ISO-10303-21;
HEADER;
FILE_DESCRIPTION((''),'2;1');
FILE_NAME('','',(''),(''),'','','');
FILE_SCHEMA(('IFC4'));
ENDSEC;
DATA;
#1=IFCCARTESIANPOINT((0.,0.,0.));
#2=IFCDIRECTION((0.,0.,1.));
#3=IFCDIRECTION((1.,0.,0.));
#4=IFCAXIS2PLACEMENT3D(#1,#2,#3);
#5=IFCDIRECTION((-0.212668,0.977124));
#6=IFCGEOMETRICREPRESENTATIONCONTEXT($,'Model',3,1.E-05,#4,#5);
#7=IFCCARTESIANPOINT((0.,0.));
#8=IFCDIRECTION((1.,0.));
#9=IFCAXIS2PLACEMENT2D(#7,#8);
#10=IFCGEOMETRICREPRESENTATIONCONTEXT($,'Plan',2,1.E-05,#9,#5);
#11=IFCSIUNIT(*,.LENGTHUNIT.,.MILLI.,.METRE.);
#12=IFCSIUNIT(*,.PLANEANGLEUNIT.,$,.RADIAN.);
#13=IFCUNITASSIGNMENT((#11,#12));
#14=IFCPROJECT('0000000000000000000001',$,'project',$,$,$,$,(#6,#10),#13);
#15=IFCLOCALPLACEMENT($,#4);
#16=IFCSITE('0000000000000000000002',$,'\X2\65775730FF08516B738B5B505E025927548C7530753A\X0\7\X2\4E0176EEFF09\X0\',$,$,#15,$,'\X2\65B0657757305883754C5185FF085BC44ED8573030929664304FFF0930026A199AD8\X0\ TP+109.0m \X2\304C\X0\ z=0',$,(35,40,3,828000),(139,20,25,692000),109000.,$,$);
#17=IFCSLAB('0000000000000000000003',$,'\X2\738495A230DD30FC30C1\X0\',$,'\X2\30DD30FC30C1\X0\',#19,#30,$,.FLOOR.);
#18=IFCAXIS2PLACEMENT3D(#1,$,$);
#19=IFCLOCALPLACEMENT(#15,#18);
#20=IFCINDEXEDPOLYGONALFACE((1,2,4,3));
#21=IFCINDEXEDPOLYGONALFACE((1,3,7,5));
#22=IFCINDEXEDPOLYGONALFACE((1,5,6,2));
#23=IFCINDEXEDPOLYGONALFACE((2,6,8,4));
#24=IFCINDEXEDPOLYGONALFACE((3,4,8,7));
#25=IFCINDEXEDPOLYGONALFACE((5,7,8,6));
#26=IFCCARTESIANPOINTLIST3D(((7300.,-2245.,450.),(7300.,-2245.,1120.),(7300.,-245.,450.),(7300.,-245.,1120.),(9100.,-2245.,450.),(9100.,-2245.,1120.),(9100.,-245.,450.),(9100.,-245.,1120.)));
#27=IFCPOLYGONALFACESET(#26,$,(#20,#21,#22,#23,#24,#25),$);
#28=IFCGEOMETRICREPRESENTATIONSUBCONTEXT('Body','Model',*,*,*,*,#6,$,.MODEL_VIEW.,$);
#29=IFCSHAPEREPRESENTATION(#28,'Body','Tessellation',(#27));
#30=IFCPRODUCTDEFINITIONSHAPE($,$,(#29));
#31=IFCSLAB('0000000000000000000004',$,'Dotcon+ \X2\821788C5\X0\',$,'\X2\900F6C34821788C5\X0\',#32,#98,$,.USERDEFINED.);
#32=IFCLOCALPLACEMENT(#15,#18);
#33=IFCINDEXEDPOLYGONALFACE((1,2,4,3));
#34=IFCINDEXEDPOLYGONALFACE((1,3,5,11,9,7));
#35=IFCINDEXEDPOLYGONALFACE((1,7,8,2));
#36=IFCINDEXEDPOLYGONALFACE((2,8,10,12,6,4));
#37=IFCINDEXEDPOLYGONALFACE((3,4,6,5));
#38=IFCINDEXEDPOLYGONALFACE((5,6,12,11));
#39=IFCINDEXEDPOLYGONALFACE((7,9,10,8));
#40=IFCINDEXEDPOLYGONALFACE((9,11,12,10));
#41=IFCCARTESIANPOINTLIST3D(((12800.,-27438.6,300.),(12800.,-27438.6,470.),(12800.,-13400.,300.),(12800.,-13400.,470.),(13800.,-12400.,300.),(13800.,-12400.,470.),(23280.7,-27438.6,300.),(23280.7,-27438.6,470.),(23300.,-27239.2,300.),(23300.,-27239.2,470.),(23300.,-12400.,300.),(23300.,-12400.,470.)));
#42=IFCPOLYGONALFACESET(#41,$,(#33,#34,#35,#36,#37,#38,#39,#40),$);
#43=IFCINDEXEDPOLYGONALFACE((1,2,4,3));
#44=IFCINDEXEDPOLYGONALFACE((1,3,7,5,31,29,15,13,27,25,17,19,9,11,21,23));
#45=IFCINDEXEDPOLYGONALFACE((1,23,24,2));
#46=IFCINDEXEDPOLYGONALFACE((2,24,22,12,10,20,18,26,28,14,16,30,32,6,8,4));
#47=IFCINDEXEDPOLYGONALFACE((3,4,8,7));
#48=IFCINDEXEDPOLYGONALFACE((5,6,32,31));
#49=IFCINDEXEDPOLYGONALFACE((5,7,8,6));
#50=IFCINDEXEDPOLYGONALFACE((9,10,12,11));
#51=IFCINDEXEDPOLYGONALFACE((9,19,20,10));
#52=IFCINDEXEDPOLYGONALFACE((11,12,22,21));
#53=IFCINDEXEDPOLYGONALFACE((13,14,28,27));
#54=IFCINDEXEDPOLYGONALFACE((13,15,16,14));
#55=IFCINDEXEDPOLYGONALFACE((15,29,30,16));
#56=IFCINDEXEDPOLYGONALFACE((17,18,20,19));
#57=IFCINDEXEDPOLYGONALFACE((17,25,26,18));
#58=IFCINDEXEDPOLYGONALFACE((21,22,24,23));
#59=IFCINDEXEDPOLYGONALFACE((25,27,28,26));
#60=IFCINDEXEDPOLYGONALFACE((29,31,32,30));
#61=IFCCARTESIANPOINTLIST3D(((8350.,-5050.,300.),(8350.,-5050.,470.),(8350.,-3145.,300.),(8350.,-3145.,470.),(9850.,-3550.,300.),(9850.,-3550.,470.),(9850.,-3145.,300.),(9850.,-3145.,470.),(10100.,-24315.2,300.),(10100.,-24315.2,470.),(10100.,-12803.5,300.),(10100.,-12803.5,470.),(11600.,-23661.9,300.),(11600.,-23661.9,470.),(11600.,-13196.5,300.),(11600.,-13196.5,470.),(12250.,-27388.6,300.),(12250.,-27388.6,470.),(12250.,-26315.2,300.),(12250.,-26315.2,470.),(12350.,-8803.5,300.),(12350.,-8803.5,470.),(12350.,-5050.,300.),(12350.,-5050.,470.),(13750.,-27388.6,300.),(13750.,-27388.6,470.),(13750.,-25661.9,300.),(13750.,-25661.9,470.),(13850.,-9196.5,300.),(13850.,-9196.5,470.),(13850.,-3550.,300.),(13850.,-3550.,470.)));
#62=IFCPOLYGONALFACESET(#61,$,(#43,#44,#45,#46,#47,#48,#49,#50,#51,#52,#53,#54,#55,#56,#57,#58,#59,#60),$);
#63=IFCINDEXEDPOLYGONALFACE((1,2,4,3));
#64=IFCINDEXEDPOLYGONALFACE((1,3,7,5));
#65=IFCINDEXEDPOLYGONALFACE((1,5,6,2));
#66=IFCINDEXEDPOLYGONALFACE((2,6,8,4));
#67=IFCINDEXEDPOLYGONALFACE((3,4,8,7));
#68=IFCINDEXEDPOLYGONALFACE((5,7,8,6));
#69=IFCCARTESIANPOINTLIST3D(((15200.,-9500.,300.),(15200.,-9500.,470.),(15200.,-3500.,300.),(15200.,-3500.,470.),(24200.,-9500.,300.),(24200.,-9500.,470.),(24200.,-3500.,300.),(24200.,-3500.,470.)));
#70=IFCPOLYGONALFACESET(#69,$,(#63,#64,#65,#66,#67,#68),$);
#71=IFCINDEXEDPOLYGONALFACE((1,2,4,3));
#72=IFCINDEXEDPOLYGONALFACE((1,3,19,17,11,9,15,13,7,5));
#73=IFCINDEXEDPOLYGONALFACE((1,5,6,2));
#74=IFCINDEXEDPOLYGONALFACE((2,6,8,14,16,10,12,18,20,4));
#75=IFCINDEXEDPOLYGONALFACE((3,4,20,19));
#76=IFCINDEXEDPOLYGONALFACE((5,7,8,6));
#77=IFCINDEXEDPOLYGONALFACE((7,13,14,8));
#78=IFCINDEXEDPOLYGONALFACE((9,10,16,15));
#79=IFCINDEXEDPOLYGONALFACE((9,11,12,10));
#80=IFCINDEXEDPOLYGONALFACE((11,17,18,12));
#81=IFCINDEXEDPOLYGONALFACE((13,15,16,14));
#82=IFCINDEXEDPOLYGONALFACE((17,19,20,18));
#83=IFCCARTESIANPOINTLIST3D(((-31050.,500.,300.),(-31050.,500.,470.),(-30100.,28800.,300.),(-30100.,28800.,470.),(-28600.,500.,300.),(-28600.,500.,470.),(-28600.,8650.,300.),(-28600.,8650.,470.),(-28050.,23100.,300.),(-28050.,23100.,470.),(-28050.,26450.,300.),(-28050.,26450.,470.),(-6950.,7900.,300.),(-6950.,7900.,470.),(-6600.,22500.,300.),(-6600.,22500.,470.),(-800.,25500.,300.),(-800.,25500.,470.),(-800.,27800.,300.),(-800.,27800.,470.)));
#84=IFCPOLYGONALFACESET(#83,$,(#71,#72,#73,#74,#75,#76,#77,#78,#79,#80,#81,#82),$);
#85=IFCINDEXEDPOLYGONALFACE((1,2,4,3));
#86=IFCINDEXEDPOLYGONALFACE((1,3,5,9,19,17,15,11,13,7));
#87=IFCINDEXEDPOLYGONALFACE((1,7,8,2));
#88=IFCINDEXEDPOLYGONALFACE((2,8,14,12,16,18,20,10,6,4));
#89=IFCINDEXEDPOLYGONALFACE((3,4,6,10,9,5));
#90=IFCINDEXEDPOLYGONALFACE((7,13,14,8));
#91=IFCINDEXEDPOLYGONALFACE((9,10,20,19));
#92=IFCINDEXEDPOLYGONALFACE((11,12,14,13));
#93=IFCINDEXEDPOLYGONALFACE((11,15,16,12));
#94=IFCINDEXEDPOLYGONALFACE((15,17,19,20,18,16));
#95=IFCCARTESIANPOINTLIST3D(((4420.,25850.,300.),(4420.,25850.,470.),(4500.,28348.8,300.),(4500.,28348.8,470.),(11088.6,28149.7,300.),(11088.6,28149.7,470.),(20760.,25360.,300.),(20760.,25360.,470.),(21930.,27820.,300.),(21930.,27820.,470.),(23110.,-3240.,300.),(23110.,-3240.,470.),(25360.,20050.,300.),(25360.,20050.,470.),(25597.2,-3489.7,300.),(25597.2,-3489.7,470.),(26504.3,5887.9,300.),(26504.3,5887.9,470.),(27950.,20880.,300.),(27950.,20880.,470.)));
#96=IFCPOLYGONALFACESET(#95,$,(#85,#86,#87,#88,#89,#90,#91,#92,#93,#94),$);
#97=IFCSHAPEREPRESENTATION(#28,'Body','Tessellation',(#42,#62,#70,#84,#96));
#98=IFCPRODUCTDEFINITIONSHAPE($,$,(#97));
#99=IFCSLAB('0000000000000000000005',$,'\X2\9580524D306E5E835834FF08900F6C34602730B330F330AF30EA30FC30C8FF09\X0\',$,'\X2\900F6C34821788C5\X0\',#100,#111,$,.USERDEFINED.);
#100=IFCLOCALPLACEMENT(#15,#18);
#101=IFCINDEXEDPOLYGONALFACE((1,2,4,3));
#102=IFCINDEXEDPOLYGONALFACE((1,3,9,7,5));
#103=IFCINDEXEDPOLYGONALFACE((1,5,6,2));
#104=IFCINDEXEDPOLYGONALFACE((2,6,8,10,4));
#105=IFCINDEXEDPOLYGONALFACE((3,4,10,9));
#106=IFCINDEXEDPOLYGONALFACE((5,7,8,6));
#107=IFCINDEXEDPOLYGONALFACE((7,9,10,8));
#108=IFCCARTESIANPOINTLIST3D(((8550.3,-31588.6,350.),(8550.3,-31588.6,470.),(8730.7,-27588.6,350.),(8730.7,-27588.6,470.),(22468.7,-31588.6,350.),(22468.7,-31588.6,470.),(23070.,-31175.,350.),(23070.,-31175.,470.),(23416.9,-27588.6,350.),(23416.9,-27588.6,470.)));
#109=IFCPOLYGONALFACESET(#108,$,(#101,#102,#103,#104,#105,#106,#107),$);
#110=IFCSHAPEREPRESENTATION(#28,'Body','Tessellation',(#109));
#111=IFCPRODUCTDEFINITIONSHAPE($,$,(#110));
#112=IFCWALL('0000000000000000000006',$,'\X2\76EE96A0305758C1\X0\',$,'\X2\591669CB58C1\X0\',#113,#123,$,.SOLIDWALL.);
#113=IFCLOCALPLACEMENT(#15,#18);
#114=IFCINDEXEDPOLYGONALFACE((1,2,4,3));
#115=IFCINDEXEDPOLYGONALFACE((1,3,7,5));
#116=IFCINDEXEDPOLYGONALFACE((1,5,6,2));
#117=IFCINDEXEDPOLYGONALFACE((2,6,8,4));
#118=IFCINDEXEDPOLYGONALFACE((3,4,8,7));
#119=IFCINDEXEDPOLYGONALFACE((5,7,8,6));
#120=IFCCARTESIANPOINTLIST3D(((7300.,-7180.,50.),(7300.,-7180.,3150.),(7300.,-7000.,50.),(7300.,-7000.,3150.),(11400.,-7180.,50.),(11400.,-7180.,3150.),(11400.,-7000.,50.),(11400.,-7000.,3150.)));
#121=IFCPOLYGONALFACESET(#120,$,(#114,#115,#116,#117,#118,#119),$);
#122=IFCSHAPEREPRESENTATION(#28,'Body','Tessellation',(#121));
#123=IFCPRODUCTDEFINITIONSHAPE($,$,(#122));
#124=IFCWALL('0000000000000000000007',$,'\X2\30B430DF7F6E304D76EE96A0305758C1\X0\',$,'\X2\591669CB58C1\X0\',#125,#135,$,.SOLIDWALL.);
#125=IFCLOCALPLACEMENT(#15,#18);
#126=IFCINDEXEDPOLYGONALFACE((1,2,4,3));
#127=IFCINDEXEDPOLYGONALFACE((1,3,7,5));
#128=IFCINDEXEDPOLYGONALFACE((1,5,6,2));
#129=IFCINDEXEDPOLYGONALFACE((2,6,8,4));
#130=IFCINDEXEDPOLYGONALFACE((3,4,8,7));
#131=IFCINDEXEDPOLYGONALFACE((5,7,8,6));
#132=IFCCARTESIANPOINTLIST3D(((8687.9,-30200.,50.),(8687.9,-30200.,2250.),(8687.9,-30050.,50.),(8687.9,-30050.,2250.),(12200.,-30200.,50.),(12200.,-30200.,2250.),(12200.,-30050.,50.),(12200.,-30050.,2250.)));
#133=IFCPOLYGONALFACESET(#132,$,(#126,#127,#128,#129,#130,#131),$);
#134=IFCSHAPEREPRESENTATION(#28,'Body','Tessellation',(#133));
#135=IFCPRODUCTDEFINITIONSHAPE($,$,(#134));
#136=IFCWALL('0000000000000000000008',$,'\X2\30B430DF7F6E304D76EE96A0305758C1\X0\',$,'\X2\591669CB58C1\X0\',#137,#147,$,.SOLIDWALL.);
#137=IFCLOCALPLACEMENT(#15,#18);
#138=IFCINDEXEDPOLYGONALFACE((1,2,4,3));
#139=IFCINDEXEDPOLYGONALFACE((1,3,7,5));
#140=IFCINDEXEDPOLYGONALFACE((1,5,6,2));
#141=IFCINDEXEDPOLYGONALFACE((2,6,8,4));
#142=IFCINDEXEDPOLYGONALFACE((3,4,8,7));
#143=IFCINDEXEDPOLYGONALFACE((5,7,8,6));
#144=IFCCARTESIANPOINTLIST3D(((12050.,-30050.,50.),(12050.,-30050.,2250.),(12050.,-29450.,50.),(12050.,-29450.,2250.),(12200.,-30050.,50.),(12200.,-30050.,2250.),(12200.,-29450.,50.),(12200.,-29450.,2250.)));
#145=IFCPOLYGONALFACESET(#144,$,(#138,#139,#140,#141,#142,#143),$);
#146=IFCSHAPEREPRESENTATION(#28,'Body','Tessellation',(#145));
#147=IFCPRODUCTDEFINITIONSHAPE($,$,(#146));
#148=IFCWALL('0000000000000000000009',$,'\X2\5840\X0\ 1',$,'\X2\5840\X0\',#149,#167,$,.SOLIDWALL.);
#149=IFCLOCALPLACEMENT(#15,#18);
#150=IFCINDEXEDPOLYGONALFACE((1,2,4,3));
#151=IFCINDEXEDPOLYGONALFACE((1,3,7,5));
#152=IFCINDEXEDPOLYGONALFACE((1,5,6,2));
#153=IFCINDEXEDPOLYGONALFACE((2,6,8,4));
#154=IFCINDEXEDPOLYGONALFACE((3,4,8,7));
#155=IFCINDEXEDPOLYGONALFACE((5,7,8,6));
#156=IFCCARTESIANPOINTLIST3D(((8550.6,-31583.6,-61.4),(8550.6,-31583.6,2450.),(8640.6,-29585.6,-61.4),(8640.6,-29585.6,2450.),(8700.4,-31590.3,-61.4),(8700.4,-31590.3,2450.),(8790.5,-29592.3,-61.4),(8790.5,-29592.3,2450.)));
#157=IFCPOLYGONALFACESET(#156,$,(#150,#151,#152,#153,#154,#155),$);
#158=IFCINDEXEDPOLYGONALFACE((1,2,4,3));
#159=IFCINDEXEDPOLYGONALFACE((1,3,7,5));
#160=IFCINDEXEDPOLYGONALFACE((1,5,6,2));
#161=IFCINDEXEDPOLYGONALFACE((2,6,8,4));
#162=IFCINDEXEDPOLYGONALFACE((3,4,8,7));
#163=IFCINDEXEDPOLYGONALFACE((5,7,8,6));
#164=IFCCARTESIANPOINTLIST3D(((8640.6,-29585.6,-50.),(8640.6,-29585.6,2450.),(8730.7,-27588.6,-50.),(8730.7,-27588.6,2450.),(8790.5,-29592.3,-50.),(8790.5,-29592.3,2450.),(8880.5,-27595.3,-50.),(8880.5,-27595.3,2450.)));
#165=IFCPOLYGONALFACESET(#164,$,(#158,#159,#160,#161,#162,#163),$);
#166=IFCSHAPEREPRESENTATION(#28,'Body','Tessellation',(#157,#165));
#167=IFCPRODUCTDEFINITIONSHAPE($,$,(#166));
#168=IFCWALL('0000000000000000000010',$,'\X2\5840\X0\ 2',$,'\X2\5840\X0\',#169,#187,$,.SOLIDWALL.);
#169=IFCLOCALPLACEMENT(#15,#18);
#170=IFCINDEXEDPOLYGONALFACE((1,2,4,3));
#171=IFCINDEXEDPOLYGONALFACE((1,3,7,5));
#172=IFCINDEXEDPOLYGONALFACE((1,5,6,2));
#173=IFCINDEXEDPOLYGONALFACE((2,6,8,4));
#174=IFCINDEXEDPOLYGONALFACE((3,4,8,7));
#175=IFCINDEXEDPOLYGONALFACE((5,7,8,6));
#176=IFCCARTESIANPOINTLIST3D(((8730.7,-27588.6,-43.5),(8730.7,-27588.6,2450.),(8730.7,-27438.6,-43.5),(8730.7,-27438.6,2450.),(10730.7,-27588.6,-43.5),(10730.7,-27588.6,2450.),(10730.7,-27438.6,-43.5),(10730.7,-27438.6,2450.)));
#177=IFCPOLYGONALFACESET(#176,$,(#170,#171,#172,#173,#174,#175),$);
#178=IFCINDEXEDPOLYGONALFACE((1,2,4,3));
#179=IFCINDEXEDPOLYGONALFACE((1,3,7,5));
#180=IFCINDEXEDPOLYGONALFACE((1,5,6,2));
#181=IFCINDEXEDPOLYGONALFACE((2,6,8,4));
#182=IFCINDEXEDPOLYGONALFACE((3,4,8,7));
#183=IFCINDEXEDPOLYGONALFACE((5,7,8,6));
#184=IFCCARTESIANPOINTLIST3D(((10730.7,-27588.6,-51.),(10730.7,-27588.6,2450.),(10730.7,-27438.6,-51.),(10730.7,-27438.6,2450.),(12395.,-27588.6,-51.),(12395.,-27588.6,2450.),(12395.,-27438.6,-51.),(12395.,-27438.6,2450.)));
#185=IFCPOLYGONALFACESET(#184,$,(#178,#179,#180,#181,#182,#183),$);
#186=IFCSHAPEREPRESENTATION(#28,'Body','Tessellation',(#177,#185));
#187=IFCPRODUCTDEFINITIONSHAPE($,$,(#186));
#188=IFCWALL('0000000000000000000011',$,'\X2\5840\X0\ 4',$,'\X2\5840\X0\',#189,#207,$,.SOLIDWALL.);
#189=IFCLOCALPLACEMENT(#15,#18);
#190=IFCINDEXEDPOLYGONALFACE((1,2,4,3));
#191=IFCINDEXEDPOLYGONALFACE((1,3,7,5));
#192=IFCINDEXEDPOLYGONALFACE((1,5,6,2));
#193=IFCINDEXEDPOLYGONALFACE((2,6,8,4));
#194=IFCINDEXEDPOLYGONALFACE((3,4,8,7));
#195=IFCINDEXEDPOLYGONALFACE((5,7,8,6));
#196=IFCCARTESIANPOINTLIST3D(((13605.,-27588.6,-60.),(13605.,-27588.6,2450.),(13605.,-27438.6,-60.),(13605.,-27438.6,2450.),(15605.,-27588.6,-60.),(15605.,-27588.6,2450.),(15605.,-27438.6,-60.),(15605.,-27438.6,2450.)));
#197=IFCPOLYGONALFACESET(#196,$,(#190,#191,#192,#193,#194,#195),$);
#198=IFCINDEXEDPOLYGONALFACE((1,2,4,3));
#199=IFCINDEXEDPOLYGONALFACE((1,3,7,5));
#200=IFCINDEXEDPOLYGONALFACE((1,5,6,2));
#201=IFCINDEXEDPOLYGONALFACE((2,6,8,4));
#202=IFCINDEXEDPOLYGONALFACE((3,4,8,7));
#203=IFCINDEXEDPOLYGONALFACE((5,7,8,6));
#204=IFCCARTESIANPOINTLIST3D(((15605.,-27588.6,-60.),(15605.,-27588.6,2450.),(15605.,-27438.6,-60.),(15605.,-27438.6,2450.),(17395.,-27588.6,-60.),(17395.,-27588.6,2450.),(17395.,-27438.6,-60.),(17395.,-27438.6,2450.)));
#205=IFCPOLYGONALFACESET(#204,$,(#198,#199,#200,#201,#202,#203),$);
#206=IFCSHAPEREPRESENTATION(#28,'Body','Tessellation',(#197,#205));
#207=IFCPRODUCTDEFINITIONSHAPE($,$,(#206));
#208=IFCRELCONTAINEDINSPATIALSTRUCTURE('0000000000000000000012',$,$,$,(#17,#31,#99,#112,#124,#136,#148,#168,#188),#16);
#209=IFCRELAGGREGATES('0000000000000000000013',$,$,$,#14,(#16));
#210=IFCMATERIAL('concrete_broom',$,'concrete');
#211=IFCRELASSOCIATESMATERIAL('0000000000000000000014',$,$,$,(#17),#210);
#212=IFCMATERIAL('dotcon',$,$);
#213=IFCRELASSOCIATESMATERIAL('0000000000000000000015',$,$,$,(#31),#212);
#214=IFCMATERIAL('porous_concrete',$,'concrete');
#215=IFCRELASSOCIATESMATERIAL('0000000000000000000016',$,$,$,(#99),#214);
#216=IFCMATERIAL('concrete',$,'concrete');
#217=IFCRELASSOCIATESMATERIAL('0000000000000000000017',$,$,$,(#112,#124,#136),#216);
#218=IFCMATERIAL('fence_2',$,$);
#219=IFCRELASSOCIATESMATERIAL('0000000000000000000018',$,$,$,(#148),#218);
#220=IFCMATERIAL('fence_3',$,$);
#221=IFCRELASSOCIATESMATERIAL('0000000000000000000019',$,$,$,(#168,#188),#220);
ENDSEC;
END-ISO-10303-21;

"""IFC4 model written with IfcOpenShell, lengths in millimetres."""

from ifc_helpers import new_model, si_unit, direction, frame, frame_2d, origin_with_axes, origin_2d_with_axis, place, context, subcontext, project, spatial, polyline, rectangle, outline, extrude, material, element, save


model = new_model("IFC4")

# Units and contexts
model_context = context("Model", 3, precision=1e-05, world=origin_with_axes(), true_north=direction((-0.212668, 0.977124)))
plan_context = context("Plan", 2, precision=1e-05, world=origin_2d_with_axis(), true_north=direction((-0.212668, 0.977124)))
body_context = subcontext(model_context, "Body", "Model", "MODEL_VIEW")
ifc_project = project(units=[si_unit("LENGTHUNIT", "METRE", prefix="MILLI"), si_unit("PLANEANGLEUNIT", "RADIAN")], contexts=[model_context, plan_context])

# Site
site_placement = place(None, origin_with_axes())
site = spatial("IfcSite", under=ifc_project, at=site_placement, Name="敷地（八王子市大和田町7丁目）", LongName="新敷地境界内（寄付地を除く）。標高 TP+109.0m が z=0", RefLatitude=(35, 40, 3, 828000), RefLongitude=(139, 20, 25, 692000), RefElevation=109000.0)

# Slabs
ifc_material_1 = material(Name="concrete_broom", Category="concrete")
slab_1_placement = place(site_placement, origin_with_axes())
element("IfcSlab", 1, at=slab_1_placement, inside=site, material=ifc_material_1, Name="玄関ポーチ", ObjectType="ポーチ", PredefinedType="FLOOR", context=body_context, shape_type="SweptSolid", body=[
    extrude(rectangle(XDim=1800.0, YDim=2000.0, at=frame_2d((8200.0, -1245.0))), frame((0.0, 0.0, 450.0)), (0.0, 0.0, 1.0), 670.0),
])
ifc_material_2 = material(Name="dotcon")
slab_2_placement = place(site_placement, origin_with_axes())
element("IfcSlab", 2, at=slab_2_placement, inside=site, material=ifc_material_2, Name="Dotcon+ 舗装", ObjectType="透水舗装", PredefinedType="USERDEFINED", context=body_context, shape_type="SweptSolid", body=[
    extrude(outline(polyline([(12800.0, -27438.6), (12800.0, -13400.0), (13800.0, -12400.0), (23300.0, -12400.0), (23300.0, -27239.2), (23280.7, -27438.6), (12800.0, -27438.6)])), frame((0.0, 0.0, 300.0)), (0.0, 0.0, 1.0), 170.0),
    extrude(outline(polyline([(10100.0, -24315.2), (10100.0, -12803.5), (12350.0, -8803.5), (12350.0, -5050.0), (8350.0, -5050.0), (8350.0, -3145.0), (9850.0, -3145.0), (9850.0, -3550.0), (13850.0, -3550.0), (13850.0, -9196.5), (11600.0, -13196.5), (11600.0, -23661.9), (13750.0, -25661.9), (13750.0, -27388.6), (12250.0, -27388.6), (12250.0, -26315.2), (10100.0, -24315.2)])), frame((0.0, 0.0, 300.0)), (0.0, 0.0, 1.0), 170.0),
    extrude(outline(polyline([(15200.0, -9500.0), (24200.0, -9500.0), (24200.0, -3500.0), (15200.0, -3500.0), (15200.0, -9500.0)])), frame((0.0, 0.0, 300.0)), (0.0, 0.0, 1.0), 170.0),
    extrude(outline(polyline([(-800.0, 27800.0), (-800.0, 25500.0), (-28050.0, 26450.0), (-28050.0, 23100.0), (-6600.0, 22500.0), (-6950.0, 7900.0), (-28600.0, 8650.0), (-28600.0, 500.0), (-31050.0, 500.0), (-30100.0, 28800.0), (-800.0, 27800.0)])), frame((0.0, 0.0, 300.0)), (0.0, 0.0, 1.0), 170.0),
    extrude(outline(polyline([(25360.0, 20050.0), (20760.0, 25360.0), (4420.0, 25850.0), (4500.0, 28348.8), (11088.6, 28149.7), (21930.0, 27820.0), (27950.0, 20880.0), (26504.3, 5887.9), (25597.2, -3489.7), (23110.0, -3240.0), (25360.0, 20050.0)])), frame((0.0, 0.0, 300.0)), (0.0, 0.0, 1.0), 170.0),
])
ifc_material_3 = material(Name="porous_concrete", Category="concrete")
slab_3_placement = place(site_placement, origin_with_axes())
element("IfcSlab", 3, at=slab_3_placement, inside=site, material=ifc_material_3, Name="門前の広場（透水性コンクリート）", ObjectType="透水舗装", PredefinedType="USERDEFINED", context=body_context, shape_type="SweptSolid", body=[
    extrude(outline(polyline([(23070.0, -31175.0), (22468.7, -31588.6), (8550.3, -31588.6), (8730.7, -27588.6), (23416.9, -27588.6), (23070.0, -31175.0)])), frame((0.0, 0.0, 350.0)), (0.0, 0.0, 1.0), 120.0),
])

# Walls
ifc_material_4 = material(Name="concrete", Category="concrete")
wall_1_placement = place(site_placement, origin_with_axes())
element("IfcWall", 4, at=wall_1_placement, inside=site, material=ifc_material_4, Name="目隠し壁", ObjectType="外構壁", PredefinedType="SOLIDWALL", context=body_context, shape_type="SweptSolid", body=[
    extrude(rectangle(XDim=4100.0, YDim=180.0, at=frame_2d((9350.0, -7090.0))), frame((0.0, 0.0, 50.0)), (0.0, 0.0, 1.0), 3100.0),
])
wall_2_placement = place(site_placement, origin_with_axes())
element("IfcWall", 5, at=wall_2_placement, inside=site, material=ifc_material_4, Name="ゴミ置き目隠し壁", ObjectType="外構壁", PredefinedType="SOLIDWALL", context=body_context, shape_type="SweptSolid", body=[
    extrude(rectangle(XDim=3512.1, YDim=150.0, at=frame_2d((10444.0, -30125.0))), frame((0.0, 0.0, 50.0)), (0.0, 0.0, 1.0), 2200.0),
])
wall_3_placement = place(site_placement, origin_with_axes())
element("IfcWall", 6, at=wall_3_placement, inside=site, material=ifc_material_4, Name="ゴミ置き目隠し壁", ObjectType="外構壁", PredefinedType="SOLIDWALL", context=body_context, shape_type="SweptSolid", body=[
    extrude(rectangle(XDim=150.0, YDim=600.0, at=frame_2d((12125.0, -29750.0))), frame((0.0, 0.0, 50.0)), (0.0, 0.0, 1.0), 2200.0),
])
ifc_material_5 = material(Name="fence_2")
wall_4_placement = place(site_placement, origin_with_axes())
element("IfcWall", 7, at=wall_4_placement, inside=site, material=ifc_material_5, Name="塀 1", ObjectType="塀", PredefinedType="SOLIDWALL", context=body_context, shape_type="SweptSolid", body=[
    extrude(outline(polyline([(8640.6, -29585.6), (8790.5, -29592.3), (8700.4, -31590.3), (8550.6, -31583.6), (8640.6, -29585.6)])), frame((0.0, 0.0, -61.4)), (0.0, 0.0, 1.0), 2511.4),
    extrude(outline(polyline([(8730.7, -27588.6), (8880.5, -27595.3), (8790.5, -29592.3), (8640.6, -29585.6), (8730.7, -27588.6)])), frame((0.0, 0.0, -50.0)), (0.0, 0.0, 1.0), 2500.0),
])
ifc_material_6 = material(Name="fence_3")
wall_5_placement = place(site_placement, origin_with_axes())
element("IfcWall", 8, at=wall_5_placement, inside=site, material=ifc_material_6, Name="塀 2", ObjectType="塀", PredefinedType="SOLIDWALL", context=body_context, shape_type="SweptSolid", body=[
    extrude(outline(polyline([(10730.7, -27438.6), (10730.7, -27588.6), (8730.7, -27588.6), (8730.7, -27438.6), (10730.7, -27438.6)])), frame((0.0, 0.0, -43.5)), (0.0, 0.0, 1.0), 2493.5),
    extrude(outline(polyline([(12395.0, -27438.6), (12395.0, -27588.6), (10730.7, -27588.6), (10730.7, -27438.6), (12395.0, -27438.6)])), frame((0.0, 0.0, -51.0)), (0.0, 0.0, 1.0), 2501.0),
])
wall_6_placement = place(site_placement, origin_with_axes())
element("IfcWall", 9, at=wall_6_placement, inside=site, material=ifc_material_6, Name="塀 4", ObjectType="塀", PredefinedType="SOLIDWALL", context=body_context, shape_type="SweptSolid", body=[
    extrude(outline(polyline([(15605.0, -27438.6), (15605.0, -27588.6), (13605.0, -27588.6), (13605.0, -27438.6), (15605.0, -27438.6)])), frame((0.0, 0.0, -60.0)), (0.0, 0.0, 1.0), 2510.0),
    extrude(outline(polyline([(17395.0, -27438.6), (17395.0, -27588.6), (15605.0, -27588.6), (15605.0, -27438.6), (17395.0, -27438.6)])), frame((0.0, 0.0, -60.0)), (0.0, 0.0, 1.0), 2510.0),
])

save(model, "model.ifc")
